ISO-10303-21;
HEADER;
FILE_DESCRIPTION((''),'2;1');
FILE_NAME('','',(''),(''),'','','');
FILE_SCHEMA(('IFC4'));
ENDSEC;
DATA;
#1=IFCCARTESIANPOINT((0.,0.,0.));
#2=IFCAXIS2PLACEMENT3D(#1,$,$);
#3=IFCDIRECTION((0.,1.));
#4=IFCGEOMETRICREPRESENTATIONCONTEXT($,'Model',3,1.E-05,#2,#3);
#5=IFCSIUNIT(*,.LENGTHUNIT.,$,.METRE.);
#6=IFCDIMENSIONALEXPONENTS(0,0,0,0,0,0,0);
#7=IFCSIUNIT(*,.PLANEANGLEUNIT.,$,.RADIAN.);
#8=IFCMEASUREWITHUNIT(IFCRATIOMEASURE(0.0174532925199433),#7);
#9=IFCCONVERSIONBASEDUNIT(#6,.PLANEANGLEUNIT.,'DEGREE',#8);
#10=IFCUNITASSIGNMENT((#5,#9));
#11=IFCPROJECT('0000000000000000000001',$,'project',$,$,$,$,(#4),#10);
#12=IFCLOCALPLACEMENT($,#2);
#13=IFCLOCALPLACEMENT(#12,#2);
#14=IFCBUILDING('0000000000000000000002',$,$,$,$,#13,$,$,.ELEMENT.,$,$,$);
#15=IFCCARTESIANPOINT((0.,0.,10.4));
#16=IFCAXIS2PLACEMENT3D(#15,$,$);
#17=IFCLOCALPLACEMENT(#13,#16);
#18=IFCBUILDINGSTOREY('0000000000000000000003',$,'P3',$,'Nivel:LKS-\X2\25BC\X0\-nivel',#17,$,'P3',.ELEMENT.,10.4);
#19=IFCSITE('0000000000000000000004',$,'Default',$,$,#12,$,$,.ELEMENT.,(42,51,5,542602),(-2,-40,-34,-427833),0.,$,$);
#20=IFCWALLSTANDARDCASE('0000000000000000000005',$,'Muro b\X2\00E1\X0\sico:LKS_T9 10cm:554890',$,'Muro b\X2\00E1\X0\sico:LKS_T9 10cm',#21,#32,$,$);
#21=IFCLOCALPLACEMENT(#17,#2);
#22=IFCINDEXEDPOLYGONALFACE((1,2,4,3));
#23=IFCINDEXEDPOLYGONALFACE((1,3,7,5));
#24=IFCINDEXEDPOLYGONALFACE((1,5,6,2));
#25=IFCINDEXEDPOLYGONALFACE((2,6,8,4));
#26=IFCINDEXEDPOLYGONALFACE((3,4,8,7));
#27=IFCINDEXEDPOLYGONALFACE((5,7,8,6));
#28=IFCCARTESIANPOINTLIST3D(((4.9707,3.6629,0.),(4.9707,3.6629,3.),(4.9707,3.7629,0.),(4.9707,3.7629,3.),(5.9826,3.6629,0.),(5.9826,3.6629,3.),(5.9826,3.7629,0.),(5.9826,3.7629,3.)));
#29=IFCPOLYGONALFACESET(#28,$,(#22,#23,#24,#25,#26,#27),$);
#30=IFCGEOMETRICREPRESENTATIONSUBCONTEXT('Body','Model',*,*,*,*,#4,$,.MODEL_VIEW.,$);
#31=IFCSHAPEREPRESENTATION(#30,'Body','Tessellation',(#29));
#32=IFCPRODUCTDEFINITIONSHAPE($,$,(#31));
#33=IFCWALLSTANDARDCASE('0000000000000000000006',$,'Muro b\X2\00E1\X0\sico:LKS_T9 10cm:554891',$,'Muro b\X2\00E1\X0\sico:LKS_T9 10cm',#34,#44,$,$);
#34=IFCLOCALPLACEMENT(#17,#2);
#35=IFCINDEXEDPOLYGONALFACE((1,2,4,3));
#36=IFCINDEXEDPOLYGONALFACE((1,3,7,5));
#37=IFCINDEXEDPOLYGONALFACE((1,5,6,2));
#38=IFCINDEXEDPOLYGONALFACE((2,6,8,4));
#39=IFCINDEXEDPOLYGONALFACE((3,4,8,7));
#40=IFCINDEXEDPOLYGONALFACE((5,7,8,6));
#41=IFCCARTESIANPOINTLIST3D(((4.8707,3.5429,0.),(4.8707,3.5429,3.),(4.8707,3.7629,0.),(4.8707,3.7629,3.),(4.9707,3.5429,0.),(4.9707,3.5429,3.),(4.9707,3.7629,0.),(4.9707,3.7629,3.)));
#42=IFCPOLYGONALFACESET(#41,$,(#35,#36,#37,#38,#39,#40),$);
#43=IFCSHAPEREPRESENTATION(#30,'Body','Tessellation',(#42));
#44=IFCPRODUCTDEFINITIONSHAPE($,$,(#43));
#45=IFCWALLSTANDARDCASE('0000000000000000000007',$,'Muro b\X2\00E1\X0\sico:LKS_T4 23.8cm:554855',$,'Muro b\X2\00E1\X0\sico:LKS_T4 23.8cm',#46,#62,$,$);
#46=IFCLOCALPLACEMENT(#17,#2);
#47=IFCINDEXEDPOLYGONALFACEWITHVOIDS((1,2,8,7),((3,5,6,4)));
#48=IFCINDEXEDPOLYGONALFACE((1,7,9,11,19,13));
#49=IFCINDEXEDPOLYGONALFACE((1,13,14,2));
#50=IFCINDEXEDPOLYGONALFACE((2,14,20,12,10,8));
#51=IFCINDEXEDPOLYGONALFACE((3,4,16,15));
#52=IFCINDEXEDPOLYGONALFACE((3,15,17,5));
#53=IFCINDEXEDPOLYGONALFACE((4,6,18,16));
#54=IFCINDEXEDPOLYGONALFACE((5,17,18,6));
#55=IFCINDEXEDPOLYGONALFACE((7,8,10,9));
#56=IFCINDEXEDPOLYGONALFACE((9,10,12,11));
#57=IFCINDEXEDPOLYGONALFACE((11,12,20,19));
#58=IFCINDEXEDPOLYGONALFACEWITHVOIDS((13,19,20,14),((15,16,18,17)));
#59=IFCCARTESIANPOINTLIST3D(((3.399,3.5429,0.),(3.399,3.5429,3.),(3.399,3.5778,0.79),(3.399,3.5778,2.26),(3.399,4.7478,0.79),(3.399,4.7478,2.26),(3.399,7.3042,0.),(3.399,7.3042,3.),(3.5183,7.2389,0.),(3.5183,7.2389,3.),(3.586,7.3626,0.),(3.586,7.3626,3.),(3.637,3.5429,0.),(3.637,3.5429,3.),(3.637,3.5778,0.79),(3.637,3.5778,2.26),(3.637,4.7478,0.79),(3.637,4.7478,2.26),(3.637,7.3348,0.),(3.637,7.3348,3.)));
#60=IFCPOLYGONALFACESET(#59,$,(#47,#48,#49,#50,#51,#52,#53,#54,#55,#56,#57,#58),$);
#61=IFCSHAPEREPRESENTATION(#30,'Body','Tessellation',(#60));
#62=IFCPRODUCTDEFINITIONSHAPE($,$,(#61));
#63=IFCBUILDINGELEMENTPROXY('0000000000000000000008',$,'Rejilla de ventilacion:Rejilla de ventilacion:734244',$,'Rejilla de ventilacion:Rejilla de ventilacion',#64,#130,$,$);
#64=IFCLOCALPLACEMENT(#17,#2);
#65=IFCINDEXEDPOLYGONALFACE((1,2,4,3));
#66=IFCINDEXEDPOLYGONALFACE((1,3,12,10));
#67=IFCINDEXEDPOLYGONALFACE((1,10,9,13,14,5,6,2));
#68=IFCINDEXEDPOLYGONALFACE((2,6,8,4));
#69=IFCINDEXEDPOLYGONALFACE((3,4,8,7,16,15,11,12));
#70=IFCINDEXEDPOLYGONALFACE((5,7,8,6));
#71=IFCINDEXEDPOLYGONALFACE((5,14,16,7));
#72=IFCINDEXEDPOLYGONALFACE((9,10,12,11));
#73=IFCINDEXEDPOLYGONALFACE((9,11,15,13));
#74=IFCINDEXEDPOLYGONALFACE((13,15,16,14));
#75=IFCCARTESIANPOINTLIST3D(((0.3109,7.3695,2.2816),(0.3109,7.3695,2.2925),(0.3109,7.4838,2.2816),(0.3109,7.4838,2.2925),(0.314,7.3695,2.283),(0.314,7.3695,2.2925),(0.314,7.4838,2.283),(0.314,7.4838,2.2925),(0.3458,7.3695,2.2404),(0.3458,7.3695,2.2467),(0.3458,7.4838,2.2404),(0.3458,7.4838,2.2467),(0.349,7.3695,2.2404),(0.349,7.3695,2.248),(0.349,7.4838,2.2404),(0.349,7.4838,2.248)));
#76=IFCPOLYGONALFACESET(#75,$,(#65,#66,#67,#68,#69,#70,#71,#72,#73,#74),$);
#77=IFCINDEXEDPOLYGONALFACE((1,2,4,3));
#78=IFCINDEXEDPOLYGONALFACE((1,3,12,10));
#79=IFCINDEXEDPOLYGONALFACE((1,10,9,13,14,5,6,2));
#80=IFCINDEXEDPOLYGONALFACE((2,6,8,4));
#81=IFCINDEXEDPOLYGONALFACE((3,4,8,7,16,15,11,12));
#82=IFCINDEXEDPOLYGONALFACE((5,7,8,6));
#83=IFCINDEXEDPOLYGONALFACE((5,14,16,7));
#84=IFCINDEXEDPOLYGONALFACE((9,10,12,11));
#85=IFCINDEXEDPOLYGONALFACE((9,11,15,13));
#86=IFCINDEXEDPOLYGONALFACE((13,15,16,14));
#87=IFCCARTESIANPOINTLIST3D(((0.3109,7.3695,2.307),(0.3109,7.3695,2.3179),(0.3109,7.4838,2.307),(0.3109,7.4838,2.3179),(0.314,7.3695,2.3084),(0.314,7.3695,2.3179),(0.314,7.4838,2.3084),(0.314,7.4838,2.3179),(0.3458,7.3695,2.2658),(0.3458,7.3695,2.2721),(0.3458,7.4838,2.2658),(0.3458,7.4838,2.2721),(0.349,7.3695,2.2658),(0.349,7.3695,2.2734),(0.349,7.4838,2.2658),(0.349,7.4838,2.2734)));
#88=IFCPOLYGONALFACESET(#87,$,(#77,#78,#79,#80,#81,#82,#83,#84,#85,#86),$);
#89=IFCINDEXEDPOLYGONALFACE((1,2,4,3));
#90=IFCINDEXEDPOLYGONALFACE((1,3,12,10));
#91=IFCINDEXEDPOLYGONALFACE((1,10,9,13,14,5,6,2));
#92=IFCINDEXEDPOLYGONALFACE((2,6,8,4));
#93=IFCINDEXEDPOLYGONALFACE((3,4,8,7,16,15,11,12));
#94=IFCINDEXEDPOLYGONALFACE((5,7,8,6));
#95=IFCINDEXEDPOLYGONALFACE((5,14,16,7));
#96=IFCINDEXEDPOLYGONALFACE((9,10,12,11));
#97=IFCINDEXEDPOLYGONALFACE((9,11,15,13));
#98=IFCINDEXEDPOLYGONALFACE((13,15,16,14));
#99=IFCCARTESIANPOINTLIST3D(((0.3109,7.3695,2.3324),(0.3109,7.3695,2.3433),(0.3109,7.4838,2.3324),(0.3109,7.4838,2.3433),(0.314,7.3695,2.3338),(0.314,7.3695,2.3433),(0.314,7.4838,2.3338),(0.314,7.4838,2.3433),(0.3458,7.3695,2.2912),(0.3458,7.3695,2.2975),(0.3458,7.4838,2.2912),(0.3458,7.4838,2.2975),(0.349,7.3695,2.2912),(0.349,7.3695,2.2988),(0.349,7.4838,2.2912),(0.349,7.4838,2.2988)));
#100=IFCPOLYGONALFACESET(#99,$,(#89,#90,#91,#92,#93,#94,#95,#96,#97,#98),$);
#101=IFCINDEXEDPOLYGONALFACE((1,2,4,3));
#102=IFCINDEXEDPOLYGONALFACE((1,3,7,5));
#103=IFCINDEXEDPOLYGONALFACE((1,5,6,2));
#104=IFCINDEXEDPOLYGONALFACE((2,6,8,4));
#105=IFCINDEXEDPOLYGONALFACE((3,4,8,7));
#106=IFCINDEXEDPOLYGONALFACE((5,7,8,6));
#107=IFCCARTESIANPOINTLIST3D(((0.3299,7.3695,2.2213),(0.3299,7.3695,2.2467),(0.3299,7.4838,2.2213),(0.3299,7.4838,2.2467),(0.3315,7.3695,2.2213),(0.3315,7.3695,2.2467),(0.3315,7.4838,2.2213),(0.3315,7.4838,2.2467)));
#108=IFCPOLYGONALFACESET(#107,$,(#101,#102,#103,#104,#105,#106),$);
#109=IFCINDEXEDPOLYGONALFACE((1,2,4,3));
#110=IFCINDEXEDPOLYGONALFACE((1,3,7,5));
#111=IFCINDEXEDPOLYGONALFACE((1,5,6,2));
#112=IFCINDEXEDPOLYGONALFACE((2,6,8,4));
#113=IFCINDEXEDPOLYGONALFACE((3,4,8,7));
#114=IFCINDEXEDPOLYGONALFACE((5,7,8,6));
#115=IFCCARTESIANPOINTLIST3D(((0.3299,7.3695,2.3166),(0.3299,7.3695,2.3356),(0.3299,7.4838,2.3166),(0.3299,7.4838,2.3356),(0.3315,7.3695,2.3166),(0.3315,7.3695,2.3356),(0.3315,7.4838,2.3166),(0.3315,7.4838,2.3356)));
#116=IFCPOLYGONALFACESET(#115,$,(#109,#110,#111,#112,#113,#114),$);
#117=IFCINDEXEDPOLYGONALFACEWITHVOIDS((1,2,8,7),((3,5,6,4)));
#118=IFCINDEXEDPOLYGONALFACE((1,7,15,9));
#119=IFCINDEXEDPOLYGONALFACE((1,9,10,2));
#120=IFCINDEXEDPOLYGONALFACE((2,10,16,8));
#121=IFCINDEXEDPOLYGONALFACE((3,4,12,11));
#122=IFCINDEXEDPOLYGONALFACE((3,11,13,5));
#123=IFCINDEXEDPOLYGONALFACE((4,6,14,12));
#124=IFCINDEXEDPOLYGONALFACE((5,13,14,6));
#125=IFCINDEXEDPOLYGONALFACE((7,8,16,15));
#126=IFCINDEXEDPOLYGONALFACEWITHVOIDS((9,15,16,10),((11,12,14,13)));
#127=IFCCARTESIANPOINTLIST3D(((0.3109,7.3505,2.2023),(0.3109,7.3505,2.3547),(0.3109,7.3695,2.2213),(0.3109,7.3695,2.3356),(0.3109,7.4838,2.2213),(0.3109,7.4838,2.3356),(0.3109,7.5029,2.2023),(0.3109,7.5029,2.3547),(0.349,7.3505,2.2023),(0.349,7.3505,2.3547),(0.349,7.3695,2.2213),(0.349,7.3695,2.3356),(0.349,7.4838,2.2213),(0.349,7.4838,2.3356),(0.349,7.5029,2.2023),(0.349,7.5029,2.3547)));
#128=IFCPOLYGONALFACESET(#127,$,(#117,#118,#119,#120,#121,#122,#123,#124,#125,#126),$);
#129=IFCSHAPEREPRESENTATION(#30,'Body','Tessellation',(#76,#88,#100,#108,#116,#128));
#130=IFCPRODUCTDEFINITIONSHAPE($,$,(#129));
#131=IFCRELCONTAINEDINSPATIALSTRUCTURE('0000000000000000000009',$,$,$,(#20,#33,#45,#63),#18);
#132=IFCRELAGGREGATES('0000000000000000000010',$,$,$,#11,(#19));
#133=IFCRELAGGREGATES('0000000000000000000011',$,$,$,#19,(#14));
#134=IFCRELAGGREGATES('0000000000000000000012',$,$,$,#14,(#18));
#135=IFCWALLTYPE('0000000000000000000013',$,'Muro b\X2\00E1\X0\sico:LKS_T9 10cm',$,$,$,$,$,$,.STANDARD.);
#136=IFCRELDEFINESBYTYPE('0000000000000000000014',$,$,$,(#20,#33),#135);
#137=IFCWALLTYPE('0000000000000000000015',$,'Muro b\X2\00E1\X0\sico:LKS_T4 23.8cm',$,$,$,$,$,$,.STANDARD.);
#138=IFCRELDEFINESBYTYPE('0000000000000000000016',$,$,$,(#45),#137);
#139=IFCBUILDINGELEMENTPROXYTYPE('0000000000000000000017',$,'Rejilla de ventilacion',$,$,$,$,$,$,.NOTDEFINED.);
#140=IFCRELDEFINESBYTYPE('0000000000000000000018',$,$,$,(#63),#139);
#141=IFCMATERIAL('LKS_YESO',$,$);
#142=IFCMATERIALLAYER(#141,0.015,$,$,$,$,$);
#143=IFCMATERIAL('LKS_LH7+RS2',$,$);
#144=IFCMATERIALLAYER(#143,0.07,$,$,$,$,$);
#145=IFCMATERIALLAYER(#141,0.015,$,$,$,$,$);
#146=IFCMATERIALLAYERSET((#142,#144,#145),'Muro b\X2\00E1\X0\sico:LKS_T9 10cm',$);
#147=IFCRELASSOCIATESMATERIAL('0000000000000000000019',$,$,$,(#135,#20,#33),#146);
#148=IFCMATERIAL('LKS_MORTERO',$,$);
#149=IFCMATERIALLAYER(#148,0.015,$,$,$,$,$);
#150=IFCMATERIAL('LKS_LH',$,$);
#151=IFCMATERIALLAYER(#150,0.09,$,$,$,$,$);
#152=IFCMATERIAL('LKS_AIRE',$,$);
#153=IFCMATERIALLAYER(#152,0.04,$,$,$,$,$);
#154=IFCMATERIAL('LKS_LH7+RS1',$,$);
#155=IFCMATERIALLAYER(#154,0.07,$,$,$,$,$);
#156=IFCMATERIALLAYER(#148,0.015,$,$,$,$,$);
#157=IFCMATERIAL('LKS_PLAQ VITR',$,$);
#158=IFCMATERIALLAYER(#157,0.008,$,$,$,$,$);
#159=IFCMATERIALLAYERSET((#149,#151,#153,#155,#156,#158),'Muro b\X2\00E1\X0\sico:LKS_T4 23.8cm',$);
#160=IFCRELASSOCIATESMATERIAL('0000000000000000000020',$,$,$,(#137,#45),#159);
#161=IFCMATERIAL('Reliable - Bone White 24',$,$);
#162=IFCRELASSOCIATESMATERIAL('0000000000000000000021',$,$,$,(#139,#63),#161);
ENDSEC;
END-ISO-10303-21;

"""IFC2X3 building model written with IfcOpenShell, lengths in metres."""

from ifc_helpers import new_model, entity, si_unit, converted_unit, direction, frame, frame_2d, origin, place, context, subcontext, project, spatial, polyline, rectangle, outline, extrude, clip, bounded_halfspace, source, transform, mapped, material, layer, layer_set, layer_usage, type_object, type_shapes, element, save


model = new_model("IFC2X3")

# Units and contexts
model_context = context("Model", 3, precision=1e-05, world=origin(), true_north=direction((0.0, 1.0)))
body_context = subcontext(model_context, "Body", "Model", "MODEL_VIEW")
ifc_project = project(units=[si_unit("LENGTHUNIT", "METRE"), converted_unit("PLANEANGLEUNIT", "DEGREE", entity("IfcRatioMeasure", 0.0174532925199433), si_unit("PLANEANGLEUNIT", "RADIAN"), dimensions=[0, 0, 0, 0, 0, 0, 0])], contexts=[model_context])

# Site, building, storey
site_placement = place(None, origin())
site = spatial("IfcSite", under=ifc_project, at=site_placement, Name="Default", CompositionType="ELEMENT", RefLatitude=(42, 51, 5, 542602), RefLongitude=(-2, -40, -34, -427833), RefElevation=0.0)
building_placement = place(site_placement, origin())
building = spatial("IfcBuilding", under=site, at=building_placement, CompositionType="ELEMENT")
storey_placement = place(building_placement, frame((0.0, 0.0, 10.4)))
storey = spatial("IfcBuildingStorey", under=building, at=storey_placement, Name="P3", ObjectType="Nivel:LKS-▼-nivel", LongName="P3", CompositionType="ELEMENT", Elevation=10.4)

# Shared definitions
ifc_material_1 = material(Name="LKS_MORTERO")
ifc_material_2 = material(Name="LKS_PLAQ VITR")

# Shared definitions
ifc_material_3 = material(Name="LKS_YESO")
ifc_layer_1 = layer(ifc_material_3, 0.015)
ifc_material_4 = material(Name="LKS_LH7+RS2")
ifc_layer_2 = layer(ifc_material_4, 0.07)
ifc_layer_3 = layer(ifc_material_3, 0.015)
ifc_layer_set_1 = layer_set([ifc_layer_1, ifc_layer_2, ifc_layer_3], Name="Muro básico:LKS_T9 10cm")
wall_type_1 = type_object("IfcWallType", Name="Muro básico:LKS_T9 10cm", PredefinedType="STANDARD", material=ifc_layer_set_1)

# Walls
ifc_layer_usage_1 = layer_usage(ifc_layer_set_1, "AXIS2", "NEGATIVE", 0.05)
wall_1_placement = place(storey_placement, frame((5.9826, 3.7129, 0.0), z_axis=(0.0, 0.0, 1.0), x_axis=(-1.0, 0.0, 0.0)))
element("IfcWallStandardCase", 1, at=wall_1_placement, inside=storey, type_object=wall_type_1, material=ifc_layer_usage_1, Name="Muro básico:LKS_T9 10cm:554890", ObjectType="Muro básico:LKS_T9 10cm", context=body_context, shape_type="SweptSolid", body=[
    extrude(rectangle(XDim=1.012, YDim=0.1, at=frame_2d((0.506, 0.0), x_axis=(-1.0, 0.0))), origin(), (0.0, 0.0, 1.0), 3.0),
])
ifc_layer_usage_2 = layer_usage(ifc_layer_set_1, "AXIS2", "NEGATIVE", 0.05)
wall_2_placement = place(storey_placement, frame((4.9207, 3.7629, 0.0), z_axis=(0.0, 0.0, 1.0), x_axis=(0.0, -1.0, 0.0)))
element("IfcWallStandardCase", 2, at=wall_2_placement, inside=storey, type_object=wall_type_1, material=ifc_layer_usage_2, Name="Muro básico:LKS_T9 10cm:554891", ObjectType="Muro básico:LKS_T9 10cm", context=body_context, shape_type="SweptSolid", body=[
    extrude(rectangle(XDim=0.22, YDim=0.1, at=frame_2d((0.11, 0.0), x_axis=(-1.0, 0.0))), origin(), (0.0, 0.0, 1.0), 3.0),
])

# Wall, opening
ifc_layer_4 = layer(ifc_material_1, 0.015)
ifc_material_5 = material(Name="LKS_LH")
ifc_layer_5 = layer(ifc_material_5, 0.09)
ifc_material_6 = material(Name="LKS_AIRE")
ifc_layer_6 = layer(ifc_material_6, 0.04)
ifc_material_7 = material(Name="LKS_LH7+RS1")
ifc_layer_7 = layer(ifc_material_7, 0.07)
ifc_layer_8 = layer(ifc_material_1, 0.015)
ifc_layer_9 = layer(ifc_material_2, 0.008)
ifc_layer_set_2 = layer_set([ifc_layer_4, ifc_layer_5, ifc_layer_6, ifc_layer_7, ifc_layer_8, ifc_layer_9], Name="Muro básico:LKS_T4 23.8cm")
ifc_layer_usage_3 = layer_usage(ifc_layer_set_2, "AXIS2", "NEGATIVE", 0.119)
wall_type_2 = type_object("IfcWallType", Name="Muro básico:LKS_T4 23.8cm", PredefinedType="STANDARD", material=ifc_layer_set_2)
wall_3_placement = place(storey_placement, frame((3.518, 7.3348, 0.0), z_axis=(0.0, 0.0, 1.0), x_axis=(0.0, -1.0, 0.0)))
wall_3 = element("IfcWallStandardCase", 3, at=wall_3_placement, inside=storey, type_object=wall_type_2, material=ifc_layer_usage_3, Name="Muro básico:LKS_T4 23.8cm:554855", ObjectType="Muro básico:LKS_T4 23.8cm", context=body_context, shape_type="Clipping", body=[
    clip(clip(extrude(outline(polyline([(0.0, 0.119), (-0.0279, 0.068), (0.0959, 0.0004), (0.0306, -0.119), (3.7919, -0.119), (3.7919, 0.111), (3.7919, 0.119), (1.7048, 0.119), (1.6048, 0.119), (0.0, 0.119)])), origin(), (0.0, 0.0, 1.0), 3.0), bounded_halfspace(frame((0.0959, 0.0004, 0.0), z_axis=(0.479561, 0.877509, 0.0), x_axis=(0.0, 0.0, -1.0)), True, frame((0.0959, 0.0004, 0.0), z_axis=(0.479561, 0.877509, 0.0), x_axis=(0.0, 0.0, -1.0)), polyline([(0.0, 0.0), (0.0, 0.141), (-3.0, 0.141), (-3.0, 0.0), (-2.67, 0.0), (0.0, 0.0)]))), bounded_halfspace(frame((0.0959, 0.0004, 3.0), z_axis=(0.877509, -0.479561, 0.0), x_axis=(0.0, 0.0, -1.0)), True, frame((0.0959, 0.0004, 3.0), z_axis=(0.877509, -0.479561, 0.0), x_axis=(0.0, 0.0, -1.0)), polyline([(0.0, 0.0), (0.0, -0.0791), (0.0, -0.1361), (3.0, -0.1361), (3.0, 0.0), (0.33, 0.0), (0.0, 0.0)]))),
])
opening_1_placement = place(wall_3_placement, frame((2.587, -0.119, 0.79)))
element("IfcOpeningElement", 4, at=opening_1_placement, cuts=wall_3, ObjectType="Opening", context=body_context, shape_type="SweptSolid", body=[
    extrude(rectangle(XDim=1.47, YDim=1.17, at=frame_2d((0.735, 0.585), x_axis=(1.0, 0.0))), frame((0.0, 0.0, 0.0), z_axis=(0.0, 1.0, 0.0), x_axis=(0.0, 0.0, 1.0)), (0.0, 0.0, 1.0), 0.238),
])

# Building element proxy
ifc_material_8 = material(Name="Reliable - Bone White 24")
building_element_proxy_type_1 = type_object("IfcBuildingElementProxyType", Name="Rejilla de ventilacion", PredefinedType="NOTDEFINED", material=ifc_material_8)
shared_shape_1 = source(origin(), body_context, "Body", "SweptSolid", [
    extrude(outline(polyline([(0.0173, 0.0159), (0.0269, 0.0159), (0.0269, 0.0191), (0.016, 0.0191), (-0.0189, -0.0159), (-0.0253, -0.0159), (-0.0253, -0.019), (-0.0176, -0.019), (0.0173, 0.0159)])), frame((-0.0571, 0.1, 1.435), z_axis=(1.0, 0.0, 0.0), x_axis=(0.0, 0.0, 1.0)), (0.0, 0.0, 1.0), 0.1143),
    extrude(outline(polyline([(0.0173, 0.0159), (0.0269, 0.0159), (0.0269, 0.0191), (0.016, 0.0191), (-0.0189, -0.0159), (-0.0253, -0.0159), (-0.0253, -0.019), (-0.0176, -0.019), (0.0173, 0.0159)])), frame((-0.0571, 0.1, 1.4604), z_axis=(1.0, 0.0, 0.0), x_axis=(0.0, 0.0, 1.0)), (0.0, 0.0, 1.0), 0.1143),
    extrude(outline(polyline([(0.0173, 0.0159), (0.0269, 0.0159), (0.0269, 0.0191), (0.016, 0.0191), (-0.0189, -0.0159), (-0.0253, -0.0159), (-0.0253, -0.019), (-0.0176, -0.019), (0.0173, 0.0159)])), frame((-0.0571, 0.1, 1.4858), z_axis=(1.0, 0.0, 0.0), x_axis=(0.0, 0.0, 1.0)), (0.0, 0.0, 1.0), 0.1143),
    extrude(rectangle(XDim=0.1143, YDim=0.0016, at=frame_2d((0.0, 0.0), x_axis=(1.0, 0.0))), frame((0.0, 0.1007, 1.3906), z_axis=(0.0, 0.0, 1.0), x_axis=(-1.0, 0.0, 0.0)), (0.0, 0.0, 1.0), 0.0254),
    extrude(rectangle(XDim=0.1143, YDim=0.0016, at=frame_2d((0.0, 0.0), x_axis=(1.0, 0.0))), frame((0.0, 0.1007, 1.4859), z_axis=(0.0, 0.0, 1.0), x_axis=(-1.0, 0.0, 0.0)), (0.0, 0.0, 1.0), 0.0191),
    extrude(outline(polyline([(-0.0762, -0.0762), (0.0762, -0.0762), (0.0762, 0.0762), (-0.0762, 0.0762), (-0.0762, -0.0762)]), holes=[polyline([(-0.0572, -0.0572), (-0.0572, 0.0572), (0.0572, 0.0572), (0.0572, -0.0572), (-0.0572, -0.0572)])]), frame((0.0, 0.0809, 1.4478), z_axis=(0.0, 1.0, 0.0), x_axis=(0.0, 0.0, 1.0)), (0.0, 0.0, 1.0), 0.0381),
])
type_shapes(building_element_proxy_type_1, [shared_shape_1])
proxy_1_placement = place(storey_placement, frame((0.23, 7.4267, 0.8307), z_axis=(0.0, 0.0, 1.0), x_axis=(0.0, -1.0, 0.0)))
element("IfcBuildingElementProxy", 5, at=proxy_1_placement, inside=storey, type_object=building_element_proxy_type_1, material=ifc_material_8, Name="Rejilla de ventilacion:Rejilla de ventilacion:734244", ObjectType="Rejilla de ventilacion:Rejilla de ventilacion", context=body_context, shape_type="MappedRepresentation", body=[
    mapped(shared_shape_1, transform((0.0, 0.0, 0.0), scale=1.0)),
])

save(model, "model.ifc")
